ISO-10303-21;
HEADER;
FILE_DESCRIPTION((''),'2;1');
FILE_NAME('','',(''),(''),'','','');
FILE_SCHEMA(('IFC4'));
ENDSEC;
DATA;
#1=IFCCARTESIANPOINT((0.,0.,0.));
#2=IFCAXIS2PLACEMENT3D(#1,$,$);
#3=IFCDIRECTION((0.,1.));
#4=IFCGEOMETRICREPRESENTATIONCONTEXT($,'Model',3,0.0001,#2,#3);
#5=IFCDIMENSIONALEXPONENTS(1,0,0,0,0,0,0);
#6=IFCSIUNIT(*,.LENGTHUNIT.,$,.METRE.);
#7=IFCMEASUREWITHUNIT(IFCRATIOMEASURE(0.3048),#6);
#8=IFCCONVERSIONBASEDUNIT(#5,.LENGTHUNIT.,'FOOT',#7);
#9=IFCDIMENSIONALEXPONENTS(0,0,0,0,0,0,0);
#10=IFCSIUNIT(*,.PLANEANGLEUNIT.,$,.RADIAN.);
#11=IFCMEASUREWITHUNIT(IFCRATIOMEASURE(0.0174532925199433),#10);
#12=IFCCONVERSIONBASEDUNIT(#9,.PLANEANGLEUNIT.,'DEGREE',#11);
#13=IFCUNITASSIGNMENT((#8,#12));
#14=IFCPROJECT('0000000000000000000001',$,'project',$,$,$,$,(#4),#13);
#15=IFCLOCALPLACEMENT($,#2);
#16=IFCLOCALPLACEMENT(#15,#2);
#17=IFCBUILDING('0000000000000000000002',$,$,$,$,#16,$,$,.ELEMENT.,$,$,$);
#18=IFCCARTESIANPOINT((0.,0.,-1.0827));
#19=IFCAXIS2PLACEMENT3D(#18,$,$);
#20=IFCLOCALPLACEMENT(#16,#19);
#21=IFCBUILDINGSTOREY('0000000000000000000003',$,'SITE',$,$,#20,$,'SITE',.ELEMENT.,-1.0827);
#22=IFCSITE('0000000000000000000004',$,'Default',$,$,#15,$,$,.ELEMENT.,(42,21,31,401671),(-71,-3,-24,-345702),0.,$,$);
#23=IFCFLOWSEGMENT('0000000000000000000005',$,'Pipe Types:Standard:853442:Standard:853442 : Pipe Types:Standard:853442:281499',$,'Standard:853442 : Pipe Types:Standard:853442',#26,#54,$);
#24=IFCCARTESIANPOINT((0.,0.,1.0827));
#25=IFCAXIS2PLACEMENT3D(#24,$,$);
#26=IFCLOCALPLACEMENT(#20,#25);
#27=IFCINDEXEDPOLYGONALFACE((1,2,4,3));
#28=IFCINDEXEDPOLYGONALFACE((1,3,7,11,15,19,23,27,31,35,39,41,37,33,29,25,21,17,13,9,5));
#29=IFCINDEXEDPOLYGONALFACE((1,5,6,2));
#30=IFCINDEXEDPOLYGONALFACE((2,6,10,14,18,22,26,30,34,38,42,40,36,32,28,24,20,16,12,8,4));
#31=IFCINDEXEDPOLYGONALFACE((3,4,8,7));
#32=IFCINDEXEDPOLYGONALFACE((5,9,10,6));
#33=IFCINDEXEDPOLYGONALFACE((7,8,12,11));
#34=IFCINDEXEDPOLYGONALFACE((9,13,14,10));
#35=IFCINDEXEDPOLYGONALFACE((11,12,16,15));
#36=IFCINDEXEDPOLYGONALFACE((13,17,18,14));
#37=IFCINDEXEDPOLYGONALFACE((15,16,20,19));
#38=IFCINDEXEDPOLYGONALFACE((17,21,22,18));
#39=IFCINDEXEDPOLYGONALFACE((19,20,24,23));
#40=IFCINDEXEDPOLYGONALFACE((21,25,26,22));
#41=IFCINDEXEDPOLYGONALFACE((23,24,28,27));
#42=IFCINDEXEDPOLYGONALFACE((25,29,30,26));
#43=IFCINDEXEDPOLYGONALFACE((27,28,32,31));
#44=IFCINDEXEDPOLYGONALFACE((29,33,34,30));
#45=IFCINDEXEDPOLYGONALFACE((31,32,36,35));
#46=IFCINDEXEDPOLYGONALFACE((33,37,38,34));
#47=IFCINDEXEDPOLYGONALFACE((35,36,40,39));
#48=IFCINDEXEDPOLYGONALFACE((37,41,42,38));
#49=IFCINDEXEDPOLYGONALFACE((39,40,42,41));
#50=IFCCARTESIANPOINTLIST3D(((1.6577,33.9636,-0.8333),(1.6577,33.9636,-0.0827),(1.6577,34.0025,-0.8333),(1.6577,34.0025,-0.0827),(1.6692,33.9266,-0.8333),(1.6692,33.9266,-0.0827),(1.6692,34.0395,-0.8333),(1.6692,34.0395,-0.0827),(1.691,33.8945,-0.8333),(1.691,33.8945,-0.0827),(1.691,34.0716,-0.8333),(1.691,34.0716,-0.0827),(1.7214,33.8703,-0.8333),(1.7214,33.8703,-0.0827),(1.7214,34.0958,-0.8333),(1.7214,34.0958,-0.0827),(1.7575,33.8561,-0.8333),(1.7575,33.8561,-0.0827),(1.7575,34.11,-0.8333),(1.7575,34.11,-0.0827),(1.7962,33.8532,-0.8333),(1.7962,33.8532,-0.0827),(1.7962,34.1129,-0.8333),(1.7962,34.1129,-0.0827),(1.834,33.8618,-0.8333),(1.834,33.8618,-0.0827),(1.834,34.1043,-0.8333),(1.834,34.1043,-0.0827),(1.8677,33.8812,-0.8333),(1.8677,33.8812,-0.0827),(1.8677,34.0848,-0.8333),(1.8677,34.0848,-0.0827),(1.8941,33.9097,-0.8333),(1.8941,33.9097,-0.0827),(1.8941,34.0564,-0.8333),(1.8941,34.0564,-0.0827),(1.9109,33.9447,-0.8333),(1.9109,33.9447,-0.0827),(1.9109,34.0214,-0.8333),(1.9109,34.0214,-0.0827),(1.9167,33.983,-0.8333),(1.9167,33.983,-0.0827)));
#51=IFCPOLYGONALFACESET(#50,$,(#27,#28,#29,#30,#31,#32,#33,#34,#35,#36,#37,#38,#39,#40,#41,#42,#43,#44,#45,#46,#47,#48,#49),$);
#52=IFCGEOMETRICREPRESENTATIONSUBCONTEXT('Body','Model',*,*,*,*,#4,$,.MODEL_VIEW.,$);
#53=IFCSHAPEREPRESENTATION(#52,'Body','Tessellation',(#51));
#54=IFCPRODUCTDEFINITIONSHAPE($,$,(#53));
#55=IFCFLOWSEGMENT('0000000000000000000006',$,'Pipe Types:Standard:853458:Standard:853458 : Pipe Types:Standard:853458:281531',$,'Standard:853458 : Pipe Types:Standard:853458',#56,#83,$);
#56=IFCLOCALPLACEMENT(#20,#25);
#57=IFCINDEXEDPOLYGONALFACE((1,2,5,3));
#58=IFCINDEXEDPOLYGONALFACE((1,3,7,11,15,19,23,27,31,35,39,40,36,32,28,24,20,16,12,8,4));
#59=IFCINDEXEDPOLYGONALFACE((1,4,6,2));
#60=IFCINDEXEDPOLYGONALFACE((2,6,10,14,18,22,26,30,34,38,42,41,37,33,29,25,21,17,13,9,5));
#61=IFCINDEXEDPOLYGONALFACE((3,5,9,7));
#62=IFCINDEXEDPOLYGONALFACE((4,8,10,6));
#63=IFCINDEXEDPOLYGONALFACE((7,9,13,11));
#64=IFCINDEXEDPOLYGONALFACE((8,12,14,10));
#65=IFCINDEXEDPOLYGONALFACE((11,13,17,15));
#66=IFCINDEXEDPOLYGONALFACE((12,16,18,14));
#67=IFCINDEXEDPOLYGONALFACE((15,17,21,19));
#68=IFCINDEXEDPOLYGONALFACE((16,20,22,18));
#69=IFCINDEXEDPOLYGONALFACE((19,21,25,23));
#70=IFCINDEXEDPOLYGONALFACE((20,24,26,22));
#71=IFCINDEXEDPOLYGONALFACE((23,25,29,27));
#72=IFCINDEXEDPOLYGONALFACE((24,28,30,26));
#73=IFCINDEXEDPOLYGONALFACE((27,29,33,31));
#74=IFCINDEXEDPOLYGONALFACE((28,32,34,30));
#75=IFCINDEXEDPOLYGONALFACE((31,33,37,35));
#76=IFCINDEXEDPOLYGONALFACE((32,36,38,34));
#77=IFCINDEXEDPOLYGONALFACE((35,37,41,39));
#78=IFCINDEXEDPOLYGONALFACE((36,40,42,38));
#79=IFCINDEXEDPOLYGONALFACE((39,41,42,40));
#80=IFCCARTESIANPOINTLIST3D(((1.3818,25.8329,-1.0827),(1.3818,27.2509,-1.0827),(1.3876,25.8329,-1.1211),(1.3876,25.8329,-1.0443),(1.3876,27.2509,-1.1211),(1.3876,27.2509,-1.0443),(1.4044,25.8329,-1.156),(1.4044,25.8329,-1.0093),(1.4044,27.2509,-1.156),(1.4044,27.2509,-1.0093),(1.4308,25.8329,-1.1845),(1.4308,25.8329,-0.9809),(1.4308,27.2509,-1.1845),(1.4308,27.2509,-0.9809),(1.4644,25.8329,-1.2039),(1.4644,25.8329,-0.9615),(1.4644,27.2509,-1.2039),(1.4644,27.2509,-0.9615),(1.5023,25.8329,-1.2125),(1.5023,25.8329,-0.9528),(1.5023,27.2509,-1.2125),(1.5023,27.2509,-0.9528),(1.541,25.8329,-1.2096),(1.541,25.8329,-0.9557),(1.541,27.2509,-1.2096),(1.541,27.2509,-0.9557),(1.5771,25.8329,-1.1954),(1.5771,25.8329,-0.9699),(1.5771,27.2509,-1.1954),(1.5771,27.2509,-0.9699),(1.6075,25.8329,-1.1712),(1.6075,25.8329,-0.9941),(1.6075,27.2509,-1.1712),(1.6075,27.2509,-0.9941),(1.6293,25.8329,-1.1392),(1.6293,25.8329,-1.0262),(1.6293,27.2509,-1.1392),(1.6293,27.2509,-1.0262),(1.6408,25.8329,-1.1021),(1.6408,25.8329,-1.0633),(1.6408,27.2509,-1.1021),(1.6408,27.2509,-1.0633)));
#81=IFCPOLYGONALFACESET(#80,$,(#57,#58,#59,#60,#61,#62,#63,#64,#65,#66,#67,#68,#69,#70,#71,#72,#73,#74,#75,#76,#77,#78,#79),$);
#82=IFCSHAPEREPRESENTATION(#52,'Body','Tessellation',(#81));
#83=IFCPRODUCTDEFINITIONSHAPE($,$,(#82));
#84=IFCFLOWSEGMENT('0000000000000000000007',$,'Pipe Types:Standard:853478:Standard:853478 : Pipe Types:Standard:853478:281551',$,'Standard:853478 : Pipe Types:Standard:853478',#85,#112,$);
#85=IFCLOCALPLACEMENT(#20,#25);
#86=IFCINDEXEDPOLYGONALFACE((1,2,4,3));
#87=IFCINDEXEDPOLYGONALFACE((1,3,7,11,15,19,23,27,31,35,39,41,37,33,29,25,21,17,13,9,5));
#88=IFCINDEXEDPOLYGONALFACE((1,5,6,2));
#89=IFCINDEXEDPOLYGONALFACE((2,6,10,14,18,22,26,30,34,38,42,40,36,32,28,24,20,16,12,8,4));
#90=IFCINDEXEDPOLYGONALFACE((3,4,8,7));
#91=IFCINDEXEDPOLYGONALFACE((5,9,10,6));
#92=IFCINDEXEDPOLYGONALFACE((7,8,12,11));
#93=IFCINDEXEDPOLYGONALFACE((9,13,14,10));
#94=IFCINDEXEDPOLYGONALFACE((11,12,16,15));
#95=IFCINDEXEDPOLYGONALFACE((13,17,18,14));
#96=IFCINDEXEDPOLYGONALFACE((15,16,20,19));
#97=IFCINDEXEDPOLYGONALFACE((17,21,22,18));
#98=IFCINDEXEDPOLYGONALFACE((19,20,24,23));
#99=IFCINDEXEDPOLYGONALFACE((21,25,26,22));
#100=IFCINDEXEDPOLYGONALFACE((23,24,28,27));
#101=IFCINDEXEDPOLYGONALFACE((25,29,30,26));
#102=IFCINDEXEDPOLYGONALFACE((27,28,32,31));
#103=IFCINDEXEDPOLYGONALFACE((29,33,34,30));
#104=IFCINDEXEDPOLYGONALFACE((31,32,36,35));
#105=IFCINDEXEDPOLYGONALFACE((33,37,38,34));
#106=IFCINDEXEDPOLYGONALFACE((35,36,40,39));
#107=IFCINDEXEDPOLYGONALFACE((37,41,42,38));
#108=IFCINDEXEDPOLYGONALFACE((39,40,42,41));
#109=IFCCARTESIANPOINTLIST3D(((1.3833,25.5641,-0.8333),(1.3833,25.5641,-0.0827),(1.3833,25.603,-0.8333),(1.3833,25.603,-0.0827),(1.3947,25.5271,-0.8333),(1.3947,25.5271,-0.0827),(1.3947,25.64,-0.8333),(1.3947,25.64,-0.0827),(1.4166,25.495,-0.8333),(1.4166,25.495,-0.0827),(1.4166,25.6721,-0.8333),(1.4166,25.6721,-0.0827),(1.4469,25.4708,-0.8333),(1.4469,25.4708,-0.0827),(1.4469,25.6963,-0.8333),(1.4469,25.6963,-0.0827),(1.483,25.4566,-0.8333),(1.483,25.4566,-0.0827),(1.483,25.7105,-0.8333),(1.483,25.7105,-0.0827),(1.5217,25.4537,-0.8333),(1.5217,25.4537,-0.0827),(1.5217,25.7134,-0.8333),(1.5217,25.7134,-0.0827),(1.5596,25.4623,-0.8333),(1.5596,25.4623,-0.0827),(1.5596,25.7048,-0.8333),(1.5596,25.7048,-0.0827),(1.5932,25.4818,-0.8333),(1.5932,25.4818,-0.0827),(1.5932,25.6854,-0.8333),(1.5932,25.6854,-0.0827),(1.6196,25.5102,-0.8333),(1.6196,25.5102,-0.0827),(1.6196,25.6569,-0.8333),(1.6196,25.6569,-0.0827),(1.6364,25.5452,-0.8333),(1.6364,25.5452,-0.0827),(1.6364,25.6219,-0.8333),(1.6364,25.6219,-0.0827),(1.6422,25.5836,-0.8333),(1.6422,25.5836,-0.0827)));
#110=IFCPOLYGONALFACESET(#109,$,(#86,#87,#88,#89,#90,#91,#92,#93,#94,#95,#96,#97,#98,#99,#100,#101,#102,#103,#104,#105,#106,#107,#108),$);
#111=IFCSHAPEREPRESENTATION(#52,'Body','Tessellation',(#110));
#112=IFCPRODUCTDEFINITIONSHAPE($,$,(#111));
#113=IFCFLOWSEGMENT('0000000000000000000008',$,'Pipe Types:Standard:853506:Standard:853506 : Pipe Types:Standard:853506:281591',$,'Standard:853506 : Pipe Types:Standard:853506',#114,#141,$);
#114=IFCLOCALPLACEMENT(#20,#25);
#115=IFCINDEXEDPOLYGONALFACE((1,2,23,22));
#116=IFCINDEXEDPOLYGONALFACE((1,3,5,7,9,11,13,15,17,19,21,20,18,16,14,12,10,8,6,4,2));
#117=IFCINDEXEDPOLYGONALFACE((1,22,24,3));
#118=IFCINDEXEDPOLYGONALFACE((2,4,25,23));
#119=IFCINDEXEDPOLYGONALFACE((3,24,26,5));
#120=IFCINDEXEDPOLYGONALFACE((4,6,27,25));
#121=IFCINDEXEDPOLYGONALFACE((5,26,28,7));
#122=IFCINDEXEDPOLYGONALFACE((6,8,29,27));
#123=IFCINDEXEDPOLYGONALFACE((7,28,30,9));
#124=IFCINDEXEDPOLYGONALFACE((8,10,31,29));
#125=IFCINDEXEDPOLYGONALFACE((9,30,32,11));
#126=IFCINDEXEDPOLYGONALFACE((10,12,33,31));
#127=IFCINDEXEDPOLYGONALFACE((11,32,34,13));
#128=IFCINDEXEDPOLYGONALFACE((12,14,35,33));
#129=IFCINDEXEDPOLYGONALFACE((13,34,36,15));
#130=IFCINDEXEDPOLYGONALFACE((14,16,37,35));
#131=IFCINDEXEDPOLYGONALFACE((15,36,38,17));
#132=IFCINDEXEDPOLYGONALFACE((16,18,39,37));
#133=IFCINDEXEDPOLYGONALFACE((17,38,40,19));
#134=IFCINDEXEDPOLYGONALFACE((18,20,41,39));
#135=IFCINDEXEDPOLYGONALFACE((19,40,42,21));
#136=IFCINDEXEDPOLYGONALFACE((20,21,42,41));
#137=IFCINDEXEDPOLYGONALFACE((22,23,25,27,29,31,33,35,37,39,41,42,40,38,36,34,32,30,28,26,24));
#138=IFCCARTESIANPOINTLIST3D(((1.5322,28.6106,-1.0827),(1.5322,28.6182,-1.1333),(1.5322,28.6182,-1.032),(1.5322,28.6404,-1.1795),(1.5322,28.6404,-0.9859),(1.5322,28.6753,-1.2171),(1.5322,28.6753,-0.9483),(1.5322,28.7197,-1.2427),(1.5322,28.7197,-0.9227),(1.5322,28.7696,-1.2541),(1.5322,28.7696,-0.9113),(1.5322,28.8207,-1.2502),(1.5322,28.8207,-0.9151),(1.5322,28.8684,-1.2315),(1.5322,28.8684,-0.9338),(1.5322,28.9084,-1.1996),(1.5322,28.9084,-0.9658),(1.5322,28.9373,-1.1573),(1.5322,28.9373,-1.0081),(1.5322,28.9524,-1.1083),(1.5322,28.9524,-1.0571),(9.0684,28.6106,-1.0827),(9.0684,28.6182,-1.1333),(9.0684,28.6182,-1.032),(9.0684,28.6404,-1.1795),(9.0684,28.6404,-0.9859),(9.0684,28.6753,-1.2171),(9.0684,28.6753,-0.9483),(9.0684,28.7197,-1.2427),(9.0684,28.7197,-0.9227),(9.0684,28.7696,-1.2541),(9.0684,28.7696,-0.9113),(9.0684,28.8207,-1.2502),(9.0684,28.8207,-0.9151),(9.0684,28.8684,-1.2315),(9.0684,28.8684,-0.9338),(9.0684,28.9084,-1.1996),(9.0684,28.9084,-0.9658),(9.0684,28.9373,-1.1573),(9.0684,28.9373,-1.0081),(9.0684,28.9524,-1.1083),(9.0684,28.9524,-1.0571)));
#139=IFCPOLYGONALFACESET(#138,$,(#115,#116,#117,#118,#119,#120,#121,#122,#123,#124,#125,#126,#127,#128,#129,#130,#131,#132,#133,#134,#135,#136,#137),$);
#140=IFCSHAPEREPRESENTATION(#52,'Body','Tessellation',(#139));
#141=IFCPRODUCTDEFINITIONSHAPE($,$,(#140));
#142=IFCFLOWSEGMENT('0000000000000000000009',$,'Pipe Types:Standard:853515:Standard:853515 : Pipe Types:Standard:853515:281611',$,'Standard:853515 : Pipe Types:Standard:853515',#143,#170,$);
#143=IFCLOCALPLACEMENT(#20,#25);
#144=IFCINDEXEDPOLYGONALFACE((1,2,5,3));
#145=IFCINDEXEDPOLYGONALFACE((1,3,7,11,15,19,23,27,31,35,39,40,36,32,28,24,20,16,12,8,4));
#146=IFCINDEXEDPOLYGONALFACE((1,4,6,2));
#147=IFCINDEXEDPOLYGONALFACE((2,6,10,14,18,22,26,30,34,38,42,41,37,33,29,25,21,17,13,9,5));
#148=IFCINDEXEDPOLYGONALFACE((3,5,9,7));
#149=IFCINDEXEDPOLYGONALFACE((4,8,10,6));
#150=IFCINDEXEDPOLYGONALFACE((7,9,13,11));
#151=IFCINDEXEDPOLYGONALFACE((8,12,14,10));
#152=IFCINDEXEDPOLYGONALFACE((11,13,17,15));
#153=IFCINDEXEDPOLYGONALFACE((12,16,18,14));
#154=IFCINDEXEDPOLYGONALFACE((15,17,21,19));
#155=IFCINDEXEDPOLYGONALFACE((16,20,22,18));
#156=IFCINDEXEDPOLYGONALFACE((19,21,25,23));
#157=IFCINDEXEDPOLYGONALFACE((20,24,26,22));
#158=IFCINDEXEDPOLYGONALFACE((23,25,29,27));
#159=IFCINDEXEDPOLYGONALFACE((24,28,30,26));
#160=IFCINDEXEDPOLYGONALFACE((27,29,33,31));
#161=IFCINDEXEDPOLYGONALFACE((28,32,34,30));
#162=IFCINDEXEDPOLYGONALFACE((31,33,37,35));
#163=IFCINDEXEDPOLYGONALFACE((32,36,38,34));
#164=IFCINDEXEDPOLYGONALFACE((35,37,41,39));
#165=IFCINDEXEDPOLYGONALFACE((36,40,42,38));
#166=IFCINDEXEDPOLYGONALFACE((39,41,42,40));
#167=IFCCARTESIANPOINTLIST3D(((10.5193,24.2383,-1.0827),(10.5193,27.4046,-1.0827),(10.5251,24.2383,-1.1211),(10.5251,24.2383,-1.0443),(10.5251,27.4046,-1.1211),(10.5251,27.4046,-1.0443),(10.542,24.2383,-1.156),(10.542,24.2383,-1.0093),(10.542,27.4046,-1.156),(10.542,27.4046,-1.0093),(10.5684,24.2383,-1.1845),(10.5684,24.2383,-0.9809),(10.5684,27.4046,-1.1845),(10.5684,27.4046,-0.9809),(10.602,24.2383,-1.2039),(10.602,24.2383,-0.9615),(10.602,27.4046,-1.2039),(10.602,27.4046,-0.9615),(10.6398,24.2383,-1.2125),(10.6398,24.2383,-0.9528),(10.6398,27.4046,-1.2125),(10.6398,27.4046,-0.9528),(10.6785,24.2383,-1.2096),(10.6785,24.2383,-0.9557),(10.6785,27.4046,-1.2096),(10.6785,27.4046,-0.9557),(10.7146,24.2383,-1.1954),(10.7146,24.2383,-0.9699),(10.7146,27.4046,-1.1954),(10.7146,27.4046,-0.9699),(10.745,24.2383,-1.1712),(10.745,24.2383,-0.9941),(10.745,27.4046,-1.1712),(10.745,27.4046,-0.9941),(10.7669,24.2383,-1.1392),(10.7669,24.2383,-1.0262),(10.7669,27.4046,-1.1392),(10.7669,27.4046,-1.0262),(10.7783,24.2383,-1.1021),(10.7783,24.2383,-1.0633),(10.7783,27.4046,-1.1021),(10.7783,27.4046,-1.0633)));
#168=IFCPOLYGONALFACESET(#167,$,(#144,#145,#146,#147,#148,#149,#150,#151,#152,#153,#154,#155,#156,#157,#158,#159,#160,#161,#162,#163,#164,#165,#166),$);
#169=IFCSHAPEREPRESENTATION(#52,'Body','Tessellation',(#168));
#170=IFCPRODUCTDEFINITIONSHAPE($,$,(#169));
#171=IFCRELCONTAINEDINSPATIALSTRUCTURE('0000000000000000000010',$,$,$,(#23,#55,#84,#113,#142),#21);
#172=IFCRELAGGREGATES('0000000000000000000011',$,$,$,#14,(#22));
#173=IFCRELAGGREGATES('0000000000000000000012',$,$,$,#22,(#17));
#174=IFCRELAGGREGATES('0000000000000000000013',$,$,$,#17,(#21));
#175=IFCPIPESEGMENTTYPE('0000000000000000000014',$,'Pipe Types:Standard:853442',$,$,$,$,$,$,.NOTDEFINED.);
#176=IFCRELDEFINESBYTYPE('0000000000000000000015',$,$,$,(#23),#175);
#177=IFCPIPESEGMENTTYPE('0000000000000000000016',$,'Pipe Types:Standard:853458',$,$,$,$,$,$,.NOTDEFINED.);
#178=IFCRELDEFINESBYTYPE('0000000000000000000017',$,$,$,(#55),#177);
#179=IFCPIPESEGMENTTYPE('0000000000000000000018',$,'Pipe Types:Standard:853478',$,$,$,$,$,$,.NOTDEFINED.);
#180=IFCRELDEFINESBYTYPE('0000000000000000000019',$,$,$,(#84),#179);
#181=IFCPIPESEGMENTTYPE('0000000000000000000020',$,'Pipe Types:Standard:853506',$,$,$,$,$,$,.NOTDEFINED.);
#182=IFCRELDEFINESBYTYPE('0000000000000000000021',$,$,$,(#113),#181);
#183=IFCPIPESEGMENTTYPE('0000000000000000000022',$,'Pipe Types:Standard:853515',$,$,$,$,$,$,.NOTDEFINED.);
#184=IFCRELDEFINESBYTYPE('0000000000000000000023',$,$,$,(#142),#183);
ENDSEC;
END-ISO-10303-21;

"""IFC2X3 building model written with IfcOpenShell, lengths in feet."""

from ifc_helpers import new_model, entity, si_unit, converted_unit, direction, frame, frame_2d, origin, origin_2d_with_axis, place, context, subcontext, project, spatial, circle, extrude, source, transform, mapped, type_object, type_shapes, element, save


model = new_model("IFC2X3")

# Units and contexts
model_context = context("Model", 3, precision=0.0001, world=origin(), true_north=direction((0.0, 1.0)))
body_context = subcontext(model_context, "Body", "Model", "MODEL_VIEW")
ifc_project = project(units=[converted_unit("LENGTHUNIT", "FOOT", entity("IfcRatioMeasure", 0.3048), si_unit("LENGTHUNIT", "METRE"), dimensions=[1, 0, 0, 0, 0, 0, 0]), converted_unit("PLANEANGLEUNIT", "DEGREE", entity("IfcRatioMeasure", 0.0174532925199433), si_unit("PLANEANGLEUNIT", "RADIAN"), dimensions=[0, 0, 0, 0, 0, 0, 0])], contexts=[model_context])

# Site, building, storey
site_placement = place(None, origin())
site = spatial("IfcSite", under=ifc_project, at=site_placement, Name="Default", CompositionType="ELEMENT", RefLatitude=(42, 21, 31, 401671), RefLongitude=(-71, -3, -24, -345702), RefElevation=0.0)
building_placement = place(site_placement, origin())
building = spatial("IfcBuilding", under=site, at=building_placement, CompositionType="ELEMENT")
storey_placement = place(building_placement, frame((0.0, 0.0, -1.0827)))
storey = spatial("IfcBuildingStorey", under=building, at=storey_placement, Name="SITE", LongName="SITE", CompositionType="ELEMENT", Elevation=-1.0827)

# Flow segments
pipe_segment_type_1 = type_object("IfcPipeSegmentType", Name="Pipe Types:Standard:853442", PredefinedType="NOTDEFINED")
shared_shape_1 = source(origin(), body_context, "Body", "SweptSolid", [
    extrude(circle(Radius=0.1302, at=origin_2d_with_axis()), frame((1.7865, 33.983, -0.8333)), (0.0, 0.0, 1.0), 0.7507),
])
type_shapes(pipe_segment_type_1, [shared_shape_1])
flow_segment_1_placement = place(storey_placement, frame((0.0, 0.0, 1.0827)))
element("IfcFlowSegment", 1, at=flow_segment_1_placement, inside=storey, type_object=pipe_segment_type_1, Name="Pipe Types:Standard:853442:Standard:853442 : Pipe Types:Standard:853442:281499", ObjectType="Standard:853442 : Pipe Types:Standard:853442", context=body_context, shape_type="MappedRepresentation", body=[
    mapped(shared_shape_1, transform((0.0, 0.0, 0.0), scale=1.0)),
])
pipe_segment_type_2 = type_object("IfcPipeSegmentType", Name="Pipe Types:Standard:853458", PredefinedType="NOTDEFINED")
shared_shape_2 = source(origin(), body_context, "Body", "SweptSolid", [
    extrude(circle(Radius=0.1302, at=frame_2d((0.0, 0.0), x_axis=(1.0, 0.0))), frame((1.512, 25.8329, -1.0827), z_axis=(0.0, 1.0, 0.0), x_axis=(-1.0, 0.0, 0.0)), (0.0, 0.0, 1.0), 1.418),
])
type_shapes(pipe_segment_type_2, [shared_shape_2])
flow_segment_2_placement = place(storey_placement, frame((0.0, 0.0, 1.0827)))
element("IfcFlowSegment", 2, at=flow_segment_2_placement, inside=storey, type_object=pipe_segment_type_2, Name="Pipe Types:Standard:853458:Standard:853458 : Pipe Types:Standard:853458:281531", ObjectType="Standard:853458 : Pipe Types:Standard:853458", context=body_context, shape_type="MappedRepresentation", body=[
    mapped(shared_shape_2, transform((0.0, 0.0, 0.0), scale=1.0)),
])
pipe_segment_type_3 = type_object("IfcPipeSegmentType", Name="Pipe Types:Standard:853478", PredefinedType="NOTDEFINED")
shared_shape_3 = source(origin(), body_context, "Body", "SweptSolid", [
    extrude(circle(Radius=0.1302, at=origin_2d_with_axis()), frame((1.512, 25.5836, -0.8333)), (0.0, 0.0, 1.0), 0.7507),
])
type_shapes(pipe_segment_type_3, [shared_shape_3])
flow_segment_3_placement = place(storey_placement, frame((0.0, 0.0, 1.0827)))
element("IfcFlowSegment", 3, at=flow_segment_3_placement, inside=storey, type_object=pipe_segment_type_3, Name="Pipe Types:Standard:853478:Standard:853478 : Pipe Types:Standard:853478:281551", ObjectType="Standard:853478 : Pipe Types:Standard:853478", context=body_context, shape_type="MappedRepresentation", body=[
    mapped(shared_shape_3, transform((0.0, 0.0, 0.0), scale=1.0)),
])
pipe_segment_type_4 = type_object("IfcPipeSegmentType", Name="Pipe Types:Standard:853506", PredefinedType="NOTDEFINED")
shared_shape_4 = source(origin(), body_context, "Body", "SweptSolid", [
    extrude(circle(Radius=0.1719, at=frame_2d((0.0, 0.0), x_axis=(1.0, 0.0))), frame((1.5322, 28.7824, -1.0827), z_axis=(1.0, 0.0, 0.0), x_axis=(0.0, -1.0, 0.0)), (0.0, 0.0, 1.0), 7.5361),
])
type_shapes(pipe_segment_type_4, [shared_shape_4])
flow_segment_4_placement = place(storey_placement, frame((0.0, 0.0, 1.0827)))
element("IfcFlowSegment", 4, at=flow_segment_4_placement, inside=storey, type_object=pipe_segment_type_4, Name="Pipe Types:Standard:853506:Standard:853506 : Pipe Types:Standard:853506:281591", ObjectType="Standard:853506 : Pipe Types:Standard:853506", context=body_context, shape_type="MappedRepresentation", body=[
    mapped(shared_shape_4, transform((0.0, 0.0, 0.0), scale=1.0)),
])
pipe_segment_type_5 = type_object("IfcPipeSegmentType", Name="Pipe Types:Standard:853515", PredefinedType="NOTDEFINED")
shared_shape_5 = source(origin(), body_context, "Body", "SweptSolid", [
    extrude(circle(Radius=0.1302, at=frame_2d((0.0, 0.0), x_axis=(1.0, 0.0))), frame((10.6495, 24.2383, -1.0827), z_axis=(0.0, 1.0, 0.0), x_axis=(-1.0, 0.0, 0.0)), (0.0, 0.0, 1.0), 3.1663),
])
type_shapes(pipe_segment_type_5, [shared_shape_5])
flow_segment_5_placement = place(storey_placement, frame((0.0, 0.0, 1.0827)))
element("IfcFlowSegment", 5, at=flow_segment_5_placement, inside=storey, type_object=pipe_segment_type_5, Name="Pipe Types:Standard:853515:Standard:853515 : Pipe Types:Standard:853515:281611", ObjectType="Standard:853515 : Pipe Types:Standard:853515", context=body_context, shape_type="MappedRepresentation", body=[
    mapped(shared_shape_5, transform((0.0, 0.0, 0.0), scale=1.0)),
])

save(model, "model.ifc")
